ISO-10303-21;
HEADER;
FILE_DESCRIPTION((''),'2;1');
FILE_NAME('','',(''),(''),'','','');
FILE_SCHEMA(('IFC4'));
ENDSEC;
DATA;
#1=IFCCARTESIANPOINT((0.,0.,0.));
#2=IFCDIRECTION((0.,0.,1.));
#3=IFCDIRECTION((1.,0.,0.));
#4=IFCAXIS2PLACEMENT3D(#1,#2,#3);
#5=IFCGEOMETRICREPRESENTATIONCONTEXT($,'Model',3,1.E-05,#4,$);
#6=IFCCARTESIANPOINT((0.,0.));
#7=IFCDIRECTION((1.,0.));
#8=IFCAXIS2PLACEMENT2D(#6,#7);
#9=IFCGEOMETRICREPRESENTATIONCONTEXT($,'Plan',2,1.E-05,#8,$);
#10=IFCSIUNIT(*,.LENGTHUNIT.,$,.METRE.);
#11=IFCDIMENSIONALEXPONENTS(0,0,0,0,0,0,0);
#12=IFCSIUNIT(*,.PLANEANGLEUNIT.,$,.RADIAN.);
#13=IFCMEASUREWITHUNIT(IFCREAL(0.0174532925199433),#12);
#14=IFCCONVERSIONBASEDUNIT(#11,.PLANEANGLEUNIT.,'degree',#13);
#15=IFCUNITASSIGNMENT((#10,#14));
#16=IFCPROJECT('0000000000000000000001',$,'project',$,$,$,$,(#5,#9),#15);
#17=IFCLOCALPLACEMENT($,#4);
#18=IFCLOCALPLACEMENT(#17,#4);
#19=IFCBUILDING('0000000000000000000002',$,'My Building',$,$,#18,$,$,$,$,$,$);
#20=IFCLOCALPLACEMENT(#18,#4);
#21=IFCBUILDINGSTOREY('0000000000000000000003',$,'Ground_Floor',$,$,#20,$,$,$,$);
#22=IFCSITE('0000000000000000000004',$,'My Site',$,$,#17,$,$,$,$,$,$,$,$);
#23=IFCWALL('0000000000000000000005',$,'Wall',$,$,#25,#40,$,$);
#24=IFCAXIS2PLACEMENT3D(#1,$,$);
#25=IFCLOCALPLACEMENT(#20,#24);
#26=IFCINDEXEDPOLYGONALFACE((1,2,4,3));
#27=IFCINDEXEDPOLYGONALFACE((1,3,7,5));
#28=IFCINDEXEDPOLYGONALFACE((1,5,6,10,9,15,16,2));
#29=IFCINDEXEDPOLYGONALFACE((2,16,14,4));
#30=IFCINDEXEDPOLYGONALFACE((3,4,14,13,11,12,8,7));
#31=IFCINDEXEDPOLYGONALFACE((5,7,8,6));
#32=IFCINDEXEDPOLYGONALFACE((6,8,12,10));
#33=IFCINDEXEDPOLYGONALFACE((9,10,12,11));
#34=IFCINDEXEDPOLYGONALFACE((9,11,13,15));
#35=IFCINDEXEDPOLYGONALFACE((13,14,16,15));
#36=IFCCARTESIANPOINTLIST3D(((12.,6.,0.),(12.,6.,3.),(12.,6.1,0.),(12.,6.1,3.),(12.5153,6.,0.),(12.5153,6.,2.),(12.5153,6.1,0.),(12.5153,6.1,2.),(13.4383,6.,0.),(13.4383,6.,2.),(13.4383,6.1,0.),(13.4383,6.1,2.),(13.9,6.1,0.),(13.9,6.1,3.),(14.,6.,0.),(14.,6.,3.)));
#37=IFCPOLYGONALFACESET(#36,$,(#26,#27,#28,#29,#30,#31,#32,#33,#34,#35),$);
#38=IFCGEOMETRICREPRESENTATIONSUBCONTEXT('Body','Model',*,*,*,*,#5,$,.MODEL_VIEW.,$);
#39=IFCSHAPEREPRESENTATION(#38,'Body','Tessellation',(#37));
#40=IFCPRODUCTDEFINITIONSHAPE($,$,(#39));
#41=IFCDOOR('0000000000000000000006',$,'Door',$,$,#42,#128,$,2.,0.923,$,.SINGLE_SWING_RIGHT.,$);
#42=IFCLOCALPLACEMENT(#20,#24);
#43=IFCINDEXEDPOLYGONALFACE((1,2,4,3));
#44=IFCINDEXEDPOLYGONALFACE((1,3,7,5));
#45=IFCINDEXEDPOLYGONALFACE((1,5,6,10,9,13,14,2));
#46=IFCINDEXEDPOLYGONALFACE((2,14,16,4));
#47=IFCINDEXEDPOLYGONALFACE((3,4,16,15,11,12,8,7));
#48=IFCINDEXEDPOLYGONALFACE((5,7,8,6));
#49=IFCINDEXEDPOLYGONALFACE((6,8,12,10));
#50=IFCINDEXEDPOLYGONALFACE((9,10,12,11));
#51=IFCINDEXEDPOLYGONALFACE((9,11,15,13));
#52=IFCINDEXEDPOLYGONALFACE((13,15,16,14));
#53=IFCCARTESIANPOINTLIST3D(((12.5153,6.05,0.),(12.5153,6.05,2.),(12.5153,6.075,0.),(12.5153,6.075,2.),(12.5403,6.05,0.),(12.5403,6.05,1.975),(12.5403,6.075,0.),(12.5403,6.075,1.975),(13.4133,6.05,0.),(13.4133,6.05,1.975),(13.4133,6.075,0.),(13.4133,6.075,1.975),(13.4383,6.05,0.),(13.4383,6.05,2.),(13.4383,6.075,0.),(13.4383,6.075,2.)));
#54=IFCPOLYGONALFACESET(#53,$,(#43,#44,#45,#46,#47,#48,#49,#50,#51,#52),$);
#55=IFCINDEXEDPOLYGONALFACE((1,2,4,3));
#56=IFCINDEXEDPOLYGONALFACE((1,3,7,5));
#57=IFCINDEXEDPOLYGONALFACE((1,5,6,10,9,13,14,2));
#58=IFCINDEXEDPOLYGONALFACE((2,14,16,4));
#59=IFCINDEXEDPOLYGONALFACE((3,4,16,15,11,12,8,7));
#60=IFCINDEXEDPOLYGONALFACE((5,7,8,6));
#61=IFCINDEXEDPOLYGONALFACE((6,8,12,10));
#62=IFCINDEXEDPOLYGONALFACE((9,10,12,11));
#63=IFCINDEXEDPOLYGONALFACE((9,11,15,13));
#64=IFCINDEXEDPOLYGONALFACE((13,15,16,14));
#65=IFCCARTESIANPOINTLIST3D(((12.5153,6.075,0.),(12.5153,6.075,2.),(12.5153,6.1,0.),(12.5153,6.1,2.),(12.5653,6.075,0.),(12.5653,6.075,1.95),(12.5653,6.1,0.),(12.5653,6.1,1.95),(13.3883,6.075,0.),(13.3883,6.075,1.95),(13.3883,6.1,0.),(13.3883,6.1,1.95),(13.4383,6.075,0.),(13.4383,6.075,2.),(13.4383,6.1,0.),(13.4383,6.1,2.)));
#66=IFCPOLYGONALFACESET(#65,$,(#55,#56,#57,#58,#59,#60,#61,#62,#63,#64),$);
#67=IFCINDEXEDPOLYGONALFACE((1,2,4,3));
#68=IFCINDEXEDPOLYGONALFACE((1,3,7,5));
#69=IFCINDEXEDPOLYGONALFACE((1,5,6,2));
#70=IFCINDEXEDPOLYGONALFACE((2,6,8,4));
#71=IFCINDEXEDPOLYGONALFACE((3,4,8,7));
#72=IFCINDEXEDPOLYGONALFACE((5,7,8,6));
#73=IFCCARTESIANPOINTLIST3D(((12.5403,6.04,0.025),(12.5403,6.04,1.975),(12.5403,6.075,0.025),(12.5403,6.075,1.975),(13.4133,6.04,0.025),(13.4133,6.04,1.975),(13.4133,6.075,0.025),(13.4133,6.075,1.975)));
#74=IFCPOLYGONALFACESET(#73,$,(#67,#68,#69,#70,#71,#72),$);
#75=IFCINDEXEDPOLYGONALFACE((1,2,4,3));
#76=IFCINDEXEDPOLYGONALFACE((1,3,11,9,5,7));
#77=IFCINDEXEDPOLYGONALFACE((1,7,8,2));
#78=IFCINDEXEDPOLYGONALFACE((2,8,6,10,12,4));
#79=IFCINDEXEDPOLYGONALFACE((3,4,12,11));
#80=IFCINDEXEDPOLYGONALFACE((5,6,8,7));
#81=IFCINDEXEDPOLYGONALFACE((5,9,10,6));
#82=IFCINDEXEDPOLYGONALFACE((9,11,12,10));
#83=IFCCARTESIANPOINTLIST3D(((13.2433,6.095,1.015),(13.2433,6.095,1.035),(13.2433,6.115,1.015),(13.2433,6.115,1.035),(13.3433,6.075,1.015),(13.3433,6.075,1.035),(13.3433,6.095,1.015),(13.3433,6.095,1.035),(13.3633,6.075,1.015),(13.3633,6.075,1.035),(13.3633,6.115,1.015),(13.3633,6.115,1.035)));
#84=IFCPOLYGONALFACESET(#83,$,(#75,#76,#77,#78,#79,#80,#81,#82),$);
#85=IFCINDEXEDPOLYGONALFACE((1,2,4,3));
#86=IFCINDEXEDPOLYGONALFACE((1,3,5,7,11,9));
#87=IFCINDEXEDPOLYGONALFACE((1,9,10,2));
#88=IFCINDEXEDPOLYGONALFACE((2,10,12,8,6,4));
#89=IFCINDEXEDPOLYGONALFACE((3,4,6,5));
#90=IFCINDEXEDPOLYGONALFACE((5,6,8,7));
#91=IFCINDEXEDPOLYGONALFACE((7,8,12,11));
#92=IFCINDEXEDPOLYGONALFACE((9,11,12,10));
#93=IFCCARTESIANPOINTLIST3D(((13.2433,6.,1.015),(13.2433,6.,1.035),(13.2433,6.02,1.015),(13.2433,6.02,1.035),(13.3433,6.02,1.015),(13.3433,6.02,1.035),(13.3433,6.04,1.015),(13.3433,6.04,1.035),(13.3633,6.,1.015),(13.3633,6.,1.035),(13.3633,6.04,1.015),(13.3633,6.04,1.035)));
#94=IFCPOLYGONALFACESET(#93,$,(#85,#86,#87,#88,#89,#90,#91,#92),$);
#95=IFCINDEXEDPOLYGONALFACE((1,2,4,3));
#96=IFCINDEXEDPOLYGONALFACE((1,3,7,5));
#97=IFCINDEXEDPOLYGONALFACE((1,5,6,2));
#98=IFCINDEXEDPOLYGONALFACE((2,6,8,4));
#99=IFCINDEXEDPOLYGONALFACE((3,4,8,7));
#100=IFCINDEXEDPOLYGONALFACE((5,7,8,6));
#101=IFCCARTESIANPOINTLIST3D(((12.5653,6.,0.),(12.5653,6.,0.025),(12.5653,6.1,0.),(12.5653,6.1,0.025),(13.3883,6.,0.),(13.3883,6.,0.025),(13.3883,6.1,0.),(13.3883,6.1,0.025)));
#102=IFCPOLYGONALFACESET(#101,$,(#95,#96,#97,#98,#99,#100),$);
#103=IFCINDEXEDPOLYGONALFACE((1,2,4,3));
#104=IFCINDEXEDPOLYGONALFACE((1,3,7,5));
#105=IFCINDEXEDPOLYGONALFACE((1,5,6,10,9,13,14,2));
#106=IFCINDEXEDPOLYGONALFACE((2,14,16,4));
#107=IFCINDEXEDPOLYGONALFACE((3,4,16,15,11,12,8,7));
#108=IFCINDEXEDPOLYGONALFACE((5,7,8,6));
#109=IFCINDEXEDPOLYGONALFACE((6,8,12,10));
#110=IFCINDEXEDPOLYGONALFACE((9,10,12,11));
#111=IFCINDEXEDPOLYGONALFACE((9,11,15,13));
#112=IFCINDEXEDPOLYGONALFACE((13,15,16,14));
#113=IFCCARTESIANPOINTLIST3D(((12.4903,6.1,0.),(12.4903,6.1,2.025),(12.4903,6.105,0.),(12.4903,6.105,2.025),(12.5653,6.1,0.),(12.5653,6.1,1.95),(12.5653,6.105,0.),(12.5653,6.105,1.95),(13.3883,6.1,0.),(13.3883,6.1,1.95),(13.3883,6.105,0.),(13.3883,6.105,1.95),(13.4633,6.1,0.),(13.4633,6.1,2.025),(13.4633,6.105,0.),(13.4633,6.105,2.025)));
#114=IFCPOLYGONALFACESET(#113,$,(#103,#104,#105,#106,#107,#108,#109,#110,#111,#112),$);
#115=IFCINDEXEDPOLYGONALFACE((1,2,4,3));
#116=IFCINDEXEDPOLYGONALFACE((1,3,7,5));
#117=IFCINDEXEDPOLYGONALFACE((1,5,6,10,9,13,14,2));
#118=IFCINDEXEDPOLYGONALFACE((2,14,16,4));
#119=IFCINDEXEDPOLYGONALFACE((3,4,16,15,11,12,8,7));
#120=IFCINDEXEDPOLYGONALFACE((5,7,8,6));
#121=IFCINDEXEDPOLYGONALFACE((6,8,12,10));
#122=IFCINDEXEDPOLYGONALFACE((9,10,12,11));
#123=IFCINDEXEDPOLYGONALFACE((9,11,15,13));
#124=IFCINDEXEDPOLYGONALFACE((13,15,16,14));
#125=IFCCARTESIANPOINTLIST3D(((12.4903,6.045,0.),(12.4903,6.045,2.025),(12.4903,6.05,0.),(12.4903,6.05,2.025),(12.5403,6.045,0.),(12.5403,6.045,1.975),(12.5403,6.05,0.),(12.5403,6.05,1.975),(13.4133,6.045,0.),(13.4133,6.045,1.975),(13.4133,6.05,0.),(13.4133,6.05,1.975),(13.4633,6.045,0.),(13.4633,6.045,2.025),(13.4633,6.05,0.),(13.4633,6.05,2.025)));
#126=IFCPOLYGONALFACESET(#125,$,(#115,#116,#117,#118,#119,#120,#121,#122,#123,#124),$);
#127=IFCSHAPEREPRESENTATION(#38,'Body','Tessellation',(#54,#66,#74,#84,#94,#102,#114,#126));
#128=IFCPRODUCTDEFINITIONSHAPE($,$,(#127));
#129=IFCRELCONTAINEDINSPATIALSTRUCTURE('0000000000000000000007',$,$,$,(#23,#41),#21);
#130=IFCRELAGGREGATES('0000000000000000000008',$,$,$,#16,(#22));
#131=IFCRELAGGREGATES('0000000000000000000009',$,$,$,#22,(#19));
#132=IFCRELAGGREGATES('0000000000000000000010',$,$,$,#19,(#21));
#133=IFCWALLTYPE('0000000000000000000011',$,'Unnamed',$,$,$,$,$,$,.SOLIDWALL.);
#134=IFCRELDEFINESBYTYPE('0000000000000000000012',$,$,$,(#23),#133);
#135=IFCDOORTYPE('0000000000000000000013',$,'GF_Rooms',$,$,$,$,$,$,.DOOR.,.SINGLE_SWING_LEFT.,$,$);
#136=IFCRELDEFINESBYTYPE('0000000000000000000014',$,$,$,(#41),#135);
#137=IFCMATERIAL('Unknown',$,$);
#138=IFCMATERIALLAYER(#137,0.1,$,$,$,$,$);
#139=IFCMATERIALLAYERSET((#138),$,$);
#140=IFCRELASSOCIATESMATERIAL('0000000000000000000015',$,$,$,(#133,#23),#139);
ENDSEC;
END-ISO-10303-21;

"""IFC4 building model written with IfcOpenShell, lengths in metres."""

from ifc_helpers import new_model, entity, si_unit, converted_unit, frame, origin_with_axes, origin_2d_with_axis, place, context, subcontext, project, spatial, line, indexed_curve, outline, extrude, shape, source, transform, mapped, material, layer, layer_set, layer_usage, type_object, type_shapes, element, fill, save


model = new_model("IFC4")

# Units and contexts
model_context = context("Model", 3, precision=1e-05, world=origin_with_axes())
plan_context = context("Plan", 2, precision=1e-05, world=origin_2d_with_axis())
body_context_1 = subcontext(model_context, "Body", "Model", "MODEL_VIEW")
body_context_2 = subcontext(plan_context, "Body", "Plan", "PLAN_VIEW")
ifc_project = project(units=[si_unit("LENGTHUNIT", "METRE"), converted_unit("PLANEANGLEUNIT", "degree", entity("IfcReal", 0.0174532925199433), si_unit("PLANEANGLEUNIT", "RADIAN"), dimensions=[0, 0, 0, 0, 0, 0, 0])], contexts=[model_context, plan_context])

# Site, building, storey
site_placement = place(None, origin_with_axes())
site = spatial("IfcSite", under=ifc_project, at=site_placement, Name="My Site")
building_placement = place(site_placement, origin_with_axes())
building = spatial("IfcBuilding", under=site, at=building_placement, Name="My Building")
storey_placement = place(building_placement, origin_with_axes())
storey = spatial("IfcBuildingStorey", under=building, at=storey_placement, Name="Ground_Floor")

# Shared definitions
ifc_material = material(Name="Unknown")
ifc_layer = layer(ifc_material, 0.1)
ifc_layer_set = layer_set([ifc_layer])
wall_type = type_object("IfcWallType", Name="Unnamed", PredefinedType="SOLIDWALL", material=ifc_layer_set)
shared_shape_1 = source(origin_with_axes(), body_context_1, "Body", "SweptSolid", [
    extrude(outline(indexed_curve([(0.0, 0.0), (0.923, 0.0), (0.923, 2.0), (0.0, 2.0)], segments=[line(1, 2, 3, 4, 1)])), frame((0.0, -0.6, 0.0), z_axis=(0.0, -1.0, 0.0), x_axis=(1.0, 0.0, 0.0)), (0.0, 0.0, -1.0), 1.2),
])
door_type_1 = type_object("IfcDoorType", Name="GF_Rooms", OperationType="SINGLE_SWING_LEFT", PredefinedType="DOOR")
shared_shape_2 = source(origin_with_axes(), body_context_1, "Body", "SweptSolid", [
    extrude(outline(indexed_curve([(0.0, 0.0), (0.0, 2.0), (0.923, 2.0), (0.923, 0.0), (0.898, 0.0), (0.898, 1.975), (0.025, 1.975), (0.025, 0.0)], segments=[line(1, 2, 3, 4, 5, 6, 7, 8, 1)])), frame((0.0, 0.025, 0.0), z_axis=(0.0, -1.0, 0.0), x_axis=(1.0, 0.0, 0.0)), (0.0, 0.0, -1.0), 0.025),
    extrude(outline(indexed_curve([(0.0, 0.0), (0.0, 2.0), (0.923, 2.0), (0.923, 0.0), (0.873, 0.0), (0.873, 1.95), (0.05, 1.95), (0.05, 0.0)], segments=[line(1, 2, 3, 4, 5, 6, 7, 8, 1)])), frame((0.0, 0.0, 0.0), z_axis=(0.0, -1.0, 0.0), x_axis=(1.0, 0.0, 0.0)), (0.0, 0.0, -1.0), 0.025),
    extrude(outline(indexed_curve([(0.0, 0.0), (0.873, 0.0), (0.873, 0.035), (0.0, 0.035)], segments=[line(1, 2, 3, 4, 1)])), frame((0.025, 0.025, 0.025), z_axis=(0.0, 0.0, 1.0), x_axis=(1.0, 0.0, 0.0)), (0.0, 0.0, 1.0), 1.95),
    extrude(outline(indexed_curve([(0.0, 0.0), (0.0, -0.04), (0.12, -0.04), (0.12, -0.02), (0.02, -0.02), (0.02, 0.0)], segments=[line(1, 2, 3, 4, 5, 6, 1)])), frame((0.075, 0.025, 1.015), z_axis=(0.0, 0.0, 1.0), x_axis=(1.0, 0.0, 0.0)), (0.0, 0.0, 1.0), 0.02),
    extrude(outline(indexed_curve([(0.0, 0.0), (0.0, 0.04), (0.12, 0.04), (0.12, 0.02), (0.02, 0.02), (0.02, 0.0)], segments=[line(1, 2, 3, 4, 5, 6, 1)])), frame((0.075, 0.06, 1.015), z_axis=(0.0, 0.0, 1.0), x_axis=(1.0, 0.0, 0.0)), (0.0, 0.0, 1.0), 0.02),
    extrude(outline(indexed_curve([(0.0, 0.0), (0.823, 0.0), (0.823, 0.1), (0.0, 0.1)], segments=[line(1, 2, 3, 4, 1)])), frame((0.05, 0.0, 0.0), z_axis=(0.0, 0.0, 1.0), x_axis=(1.0, 0.0, 0.0)), (0.0, 0.0, 1.0), 0.025),
    extrude(outline(indexed_curve([(0.0, 0.0), (0.0, 2.025), (0.973, 2.025), (0.973, 0.0), (0.898, 0.0), (0.898, 1.95), (0.075, 1.95), (0.075, 0.0)], segments=[line(1, 2, 3, 4, 5, 6, 7, 8, 1)])), frame((-0.025, -0.005, 0.0), z_axis=(0.0, -1.0, 0.0), x_axis=(1.0, 0.0, 0.0)), (0.0, 0.0, -1.0), 0.005),
    extrude(outline(indexed_curve([(0.0, 0.0), (0.0, 2.025), (0.973, 2.025), (0.973, 0.0), (0.923, 0.0), (0.923, 1.975), (0.05, 1.975), (0.05, 0.0)], segments=[line(1, 2, 3, 4, 5, 6, 7, 8, 1)])), frame((-0.025, 0.05, 0.0), z_axis=(0.0, -1.0, 0.0), x_axis=(1.0, 0.0, 0.0)), (0.0, 0.0, -1.0), 0.005),
])
shared_shape_3 = source(origin_with_axes(), body_context_2, "Body", "Curve2D", [
    entity("IfcIndexedPolyCurve", entity("IfcCartesianPointList2D", [[0.0, 0.0], [0.0, 0.05], [0.025, 0.05], [0.025, 0.025], [0.05, 0.025], [0.05, 0.0]]), [entity("IfcLineIndex", [1, 2, 3, 4, 5, 6, 1])]),
    entity("IfcIndexedPolyCurve", entity("IfcCartesianPointList2D", [[0.923, 0.0], [0.923, 0.05], [0.898, 0.05], [0.898, 0.025], [0.873, 0.025], [0.873, 0.0]]), [entity("IfcLineIndex", [1, 2, 3, 4, 5, 6, 1])]),
    entity("IfcTrimmedCurve", entity("IfcEllipse", entity("IfcAxis2Placement2D", entity("IfcCartesianPoint", [0.863, 0.05]), entity("IfcDirection", [1.0, 0.0])), 0.838, 0.873), [entity("IfcCartesianPoint", [0.863, 0.923])], [entity("IfcCartesianPoint", [0.025, 0.05])], True, "CARTESIAN"),
    entity("IfcIndexedPolyCurve", entity("IfcCartesianPointList2D", [[0.898, 0.05], [0.863, 0.05], [0.863, 0.923], [0.898, 0.923]]), [entity("IfcLineIndex", [1, 2, 3, 4, 1])]),
])
type_shapes(door_type_1, [shared_shape_2, shared_shape_3])

# Wall, opening, door
ifc_layer_usage_1 = layer_usage(ifc_layer_set, "AXIS2", "POSITIVE", 0.0)
wall_1_placement = place(storey_placement, frame((12.0, 6.0, 0.0), z_axis=(0.0, 0.0, 1.0), x_axis=(1.0, 0.0, 0.0)))
wall_1 = element("IfcWall", 1, at=wall_1_placement, inside=storey, type_object=wall_type, material=ifc_layer_usage_1, Name="Wall", context=body_context_1, shape_type="SweptSolid", body=[
    extrude(outline(indexed_curve([(0.0, 0.0), (0.0, 0.1), (1.9, 0.1), (2.0, 0.0)], segments=[line(1, 2, 3, 4, 1)])), origin_with_axes(), (0.0, 0.0, 1.0), 3.0),
])
opening_1_placement = place(wall_1_placement, frame((1.4383, 0.1, 0.0), z_axis=(0.0, 0.0, 1.0), x_axis=(-1.0, 0.0, 0.0)))
opening_1 = element("IfcOpeningElement", 2, at=opening_1_placement, cuts=wall_1, PredefinedType="OPENING", context=body_context_1, shape_type="MappedRepresentation", body=[
    mapped(shared_shape_1, transform((0.0, 0.0, 0.0), x_axis=(1.0, 0.0, 0.0), y_axis=(0.0, 1.0, 0.0), z_axis=(0.0, 0.0, 1.0), scale=1.0)),
])
door_1_placement = place(opening_1_placement, frame((0.0, 0.0, 0.0), z_axis=(0.0, 0.0, 1.0), x_axis=(1.0, 0.0, 0.0)))
door_1 = element("IfcDoor", 3, at=door_1_placement, inside=storey, type_object=door_type_1, Name="Door", OperationType="SINGLE_SWING_RIGHT", OverallHeight=2.0, OverallWidth=0.923, shapes=[
    shape(body_context_1, "Body", "MappedRepresentation", [mapped(shared_shape_2, transform((0.0, 0.0, 0.0), x_axis=(1.0, 0.0, 0.0), y_axis=(0.0, 1.0, 0.0), z_axis=(0.0, 0.0, 1.0), scale=1.0))]),
    shape(body_context_2, "Body", "MappedRepresentation", [mapped(shared_shape_3, transform((0.0, 0.0, 0.0), x_axis=(1.0, 0.0, 0.0), y_axis=(0.0, 1.0, 0.0), z_axis=(0.0, 0.0, 1.0), scale=1.0))]),
])
fill(opening_1, door_1)

save(model, "model.ifc")
